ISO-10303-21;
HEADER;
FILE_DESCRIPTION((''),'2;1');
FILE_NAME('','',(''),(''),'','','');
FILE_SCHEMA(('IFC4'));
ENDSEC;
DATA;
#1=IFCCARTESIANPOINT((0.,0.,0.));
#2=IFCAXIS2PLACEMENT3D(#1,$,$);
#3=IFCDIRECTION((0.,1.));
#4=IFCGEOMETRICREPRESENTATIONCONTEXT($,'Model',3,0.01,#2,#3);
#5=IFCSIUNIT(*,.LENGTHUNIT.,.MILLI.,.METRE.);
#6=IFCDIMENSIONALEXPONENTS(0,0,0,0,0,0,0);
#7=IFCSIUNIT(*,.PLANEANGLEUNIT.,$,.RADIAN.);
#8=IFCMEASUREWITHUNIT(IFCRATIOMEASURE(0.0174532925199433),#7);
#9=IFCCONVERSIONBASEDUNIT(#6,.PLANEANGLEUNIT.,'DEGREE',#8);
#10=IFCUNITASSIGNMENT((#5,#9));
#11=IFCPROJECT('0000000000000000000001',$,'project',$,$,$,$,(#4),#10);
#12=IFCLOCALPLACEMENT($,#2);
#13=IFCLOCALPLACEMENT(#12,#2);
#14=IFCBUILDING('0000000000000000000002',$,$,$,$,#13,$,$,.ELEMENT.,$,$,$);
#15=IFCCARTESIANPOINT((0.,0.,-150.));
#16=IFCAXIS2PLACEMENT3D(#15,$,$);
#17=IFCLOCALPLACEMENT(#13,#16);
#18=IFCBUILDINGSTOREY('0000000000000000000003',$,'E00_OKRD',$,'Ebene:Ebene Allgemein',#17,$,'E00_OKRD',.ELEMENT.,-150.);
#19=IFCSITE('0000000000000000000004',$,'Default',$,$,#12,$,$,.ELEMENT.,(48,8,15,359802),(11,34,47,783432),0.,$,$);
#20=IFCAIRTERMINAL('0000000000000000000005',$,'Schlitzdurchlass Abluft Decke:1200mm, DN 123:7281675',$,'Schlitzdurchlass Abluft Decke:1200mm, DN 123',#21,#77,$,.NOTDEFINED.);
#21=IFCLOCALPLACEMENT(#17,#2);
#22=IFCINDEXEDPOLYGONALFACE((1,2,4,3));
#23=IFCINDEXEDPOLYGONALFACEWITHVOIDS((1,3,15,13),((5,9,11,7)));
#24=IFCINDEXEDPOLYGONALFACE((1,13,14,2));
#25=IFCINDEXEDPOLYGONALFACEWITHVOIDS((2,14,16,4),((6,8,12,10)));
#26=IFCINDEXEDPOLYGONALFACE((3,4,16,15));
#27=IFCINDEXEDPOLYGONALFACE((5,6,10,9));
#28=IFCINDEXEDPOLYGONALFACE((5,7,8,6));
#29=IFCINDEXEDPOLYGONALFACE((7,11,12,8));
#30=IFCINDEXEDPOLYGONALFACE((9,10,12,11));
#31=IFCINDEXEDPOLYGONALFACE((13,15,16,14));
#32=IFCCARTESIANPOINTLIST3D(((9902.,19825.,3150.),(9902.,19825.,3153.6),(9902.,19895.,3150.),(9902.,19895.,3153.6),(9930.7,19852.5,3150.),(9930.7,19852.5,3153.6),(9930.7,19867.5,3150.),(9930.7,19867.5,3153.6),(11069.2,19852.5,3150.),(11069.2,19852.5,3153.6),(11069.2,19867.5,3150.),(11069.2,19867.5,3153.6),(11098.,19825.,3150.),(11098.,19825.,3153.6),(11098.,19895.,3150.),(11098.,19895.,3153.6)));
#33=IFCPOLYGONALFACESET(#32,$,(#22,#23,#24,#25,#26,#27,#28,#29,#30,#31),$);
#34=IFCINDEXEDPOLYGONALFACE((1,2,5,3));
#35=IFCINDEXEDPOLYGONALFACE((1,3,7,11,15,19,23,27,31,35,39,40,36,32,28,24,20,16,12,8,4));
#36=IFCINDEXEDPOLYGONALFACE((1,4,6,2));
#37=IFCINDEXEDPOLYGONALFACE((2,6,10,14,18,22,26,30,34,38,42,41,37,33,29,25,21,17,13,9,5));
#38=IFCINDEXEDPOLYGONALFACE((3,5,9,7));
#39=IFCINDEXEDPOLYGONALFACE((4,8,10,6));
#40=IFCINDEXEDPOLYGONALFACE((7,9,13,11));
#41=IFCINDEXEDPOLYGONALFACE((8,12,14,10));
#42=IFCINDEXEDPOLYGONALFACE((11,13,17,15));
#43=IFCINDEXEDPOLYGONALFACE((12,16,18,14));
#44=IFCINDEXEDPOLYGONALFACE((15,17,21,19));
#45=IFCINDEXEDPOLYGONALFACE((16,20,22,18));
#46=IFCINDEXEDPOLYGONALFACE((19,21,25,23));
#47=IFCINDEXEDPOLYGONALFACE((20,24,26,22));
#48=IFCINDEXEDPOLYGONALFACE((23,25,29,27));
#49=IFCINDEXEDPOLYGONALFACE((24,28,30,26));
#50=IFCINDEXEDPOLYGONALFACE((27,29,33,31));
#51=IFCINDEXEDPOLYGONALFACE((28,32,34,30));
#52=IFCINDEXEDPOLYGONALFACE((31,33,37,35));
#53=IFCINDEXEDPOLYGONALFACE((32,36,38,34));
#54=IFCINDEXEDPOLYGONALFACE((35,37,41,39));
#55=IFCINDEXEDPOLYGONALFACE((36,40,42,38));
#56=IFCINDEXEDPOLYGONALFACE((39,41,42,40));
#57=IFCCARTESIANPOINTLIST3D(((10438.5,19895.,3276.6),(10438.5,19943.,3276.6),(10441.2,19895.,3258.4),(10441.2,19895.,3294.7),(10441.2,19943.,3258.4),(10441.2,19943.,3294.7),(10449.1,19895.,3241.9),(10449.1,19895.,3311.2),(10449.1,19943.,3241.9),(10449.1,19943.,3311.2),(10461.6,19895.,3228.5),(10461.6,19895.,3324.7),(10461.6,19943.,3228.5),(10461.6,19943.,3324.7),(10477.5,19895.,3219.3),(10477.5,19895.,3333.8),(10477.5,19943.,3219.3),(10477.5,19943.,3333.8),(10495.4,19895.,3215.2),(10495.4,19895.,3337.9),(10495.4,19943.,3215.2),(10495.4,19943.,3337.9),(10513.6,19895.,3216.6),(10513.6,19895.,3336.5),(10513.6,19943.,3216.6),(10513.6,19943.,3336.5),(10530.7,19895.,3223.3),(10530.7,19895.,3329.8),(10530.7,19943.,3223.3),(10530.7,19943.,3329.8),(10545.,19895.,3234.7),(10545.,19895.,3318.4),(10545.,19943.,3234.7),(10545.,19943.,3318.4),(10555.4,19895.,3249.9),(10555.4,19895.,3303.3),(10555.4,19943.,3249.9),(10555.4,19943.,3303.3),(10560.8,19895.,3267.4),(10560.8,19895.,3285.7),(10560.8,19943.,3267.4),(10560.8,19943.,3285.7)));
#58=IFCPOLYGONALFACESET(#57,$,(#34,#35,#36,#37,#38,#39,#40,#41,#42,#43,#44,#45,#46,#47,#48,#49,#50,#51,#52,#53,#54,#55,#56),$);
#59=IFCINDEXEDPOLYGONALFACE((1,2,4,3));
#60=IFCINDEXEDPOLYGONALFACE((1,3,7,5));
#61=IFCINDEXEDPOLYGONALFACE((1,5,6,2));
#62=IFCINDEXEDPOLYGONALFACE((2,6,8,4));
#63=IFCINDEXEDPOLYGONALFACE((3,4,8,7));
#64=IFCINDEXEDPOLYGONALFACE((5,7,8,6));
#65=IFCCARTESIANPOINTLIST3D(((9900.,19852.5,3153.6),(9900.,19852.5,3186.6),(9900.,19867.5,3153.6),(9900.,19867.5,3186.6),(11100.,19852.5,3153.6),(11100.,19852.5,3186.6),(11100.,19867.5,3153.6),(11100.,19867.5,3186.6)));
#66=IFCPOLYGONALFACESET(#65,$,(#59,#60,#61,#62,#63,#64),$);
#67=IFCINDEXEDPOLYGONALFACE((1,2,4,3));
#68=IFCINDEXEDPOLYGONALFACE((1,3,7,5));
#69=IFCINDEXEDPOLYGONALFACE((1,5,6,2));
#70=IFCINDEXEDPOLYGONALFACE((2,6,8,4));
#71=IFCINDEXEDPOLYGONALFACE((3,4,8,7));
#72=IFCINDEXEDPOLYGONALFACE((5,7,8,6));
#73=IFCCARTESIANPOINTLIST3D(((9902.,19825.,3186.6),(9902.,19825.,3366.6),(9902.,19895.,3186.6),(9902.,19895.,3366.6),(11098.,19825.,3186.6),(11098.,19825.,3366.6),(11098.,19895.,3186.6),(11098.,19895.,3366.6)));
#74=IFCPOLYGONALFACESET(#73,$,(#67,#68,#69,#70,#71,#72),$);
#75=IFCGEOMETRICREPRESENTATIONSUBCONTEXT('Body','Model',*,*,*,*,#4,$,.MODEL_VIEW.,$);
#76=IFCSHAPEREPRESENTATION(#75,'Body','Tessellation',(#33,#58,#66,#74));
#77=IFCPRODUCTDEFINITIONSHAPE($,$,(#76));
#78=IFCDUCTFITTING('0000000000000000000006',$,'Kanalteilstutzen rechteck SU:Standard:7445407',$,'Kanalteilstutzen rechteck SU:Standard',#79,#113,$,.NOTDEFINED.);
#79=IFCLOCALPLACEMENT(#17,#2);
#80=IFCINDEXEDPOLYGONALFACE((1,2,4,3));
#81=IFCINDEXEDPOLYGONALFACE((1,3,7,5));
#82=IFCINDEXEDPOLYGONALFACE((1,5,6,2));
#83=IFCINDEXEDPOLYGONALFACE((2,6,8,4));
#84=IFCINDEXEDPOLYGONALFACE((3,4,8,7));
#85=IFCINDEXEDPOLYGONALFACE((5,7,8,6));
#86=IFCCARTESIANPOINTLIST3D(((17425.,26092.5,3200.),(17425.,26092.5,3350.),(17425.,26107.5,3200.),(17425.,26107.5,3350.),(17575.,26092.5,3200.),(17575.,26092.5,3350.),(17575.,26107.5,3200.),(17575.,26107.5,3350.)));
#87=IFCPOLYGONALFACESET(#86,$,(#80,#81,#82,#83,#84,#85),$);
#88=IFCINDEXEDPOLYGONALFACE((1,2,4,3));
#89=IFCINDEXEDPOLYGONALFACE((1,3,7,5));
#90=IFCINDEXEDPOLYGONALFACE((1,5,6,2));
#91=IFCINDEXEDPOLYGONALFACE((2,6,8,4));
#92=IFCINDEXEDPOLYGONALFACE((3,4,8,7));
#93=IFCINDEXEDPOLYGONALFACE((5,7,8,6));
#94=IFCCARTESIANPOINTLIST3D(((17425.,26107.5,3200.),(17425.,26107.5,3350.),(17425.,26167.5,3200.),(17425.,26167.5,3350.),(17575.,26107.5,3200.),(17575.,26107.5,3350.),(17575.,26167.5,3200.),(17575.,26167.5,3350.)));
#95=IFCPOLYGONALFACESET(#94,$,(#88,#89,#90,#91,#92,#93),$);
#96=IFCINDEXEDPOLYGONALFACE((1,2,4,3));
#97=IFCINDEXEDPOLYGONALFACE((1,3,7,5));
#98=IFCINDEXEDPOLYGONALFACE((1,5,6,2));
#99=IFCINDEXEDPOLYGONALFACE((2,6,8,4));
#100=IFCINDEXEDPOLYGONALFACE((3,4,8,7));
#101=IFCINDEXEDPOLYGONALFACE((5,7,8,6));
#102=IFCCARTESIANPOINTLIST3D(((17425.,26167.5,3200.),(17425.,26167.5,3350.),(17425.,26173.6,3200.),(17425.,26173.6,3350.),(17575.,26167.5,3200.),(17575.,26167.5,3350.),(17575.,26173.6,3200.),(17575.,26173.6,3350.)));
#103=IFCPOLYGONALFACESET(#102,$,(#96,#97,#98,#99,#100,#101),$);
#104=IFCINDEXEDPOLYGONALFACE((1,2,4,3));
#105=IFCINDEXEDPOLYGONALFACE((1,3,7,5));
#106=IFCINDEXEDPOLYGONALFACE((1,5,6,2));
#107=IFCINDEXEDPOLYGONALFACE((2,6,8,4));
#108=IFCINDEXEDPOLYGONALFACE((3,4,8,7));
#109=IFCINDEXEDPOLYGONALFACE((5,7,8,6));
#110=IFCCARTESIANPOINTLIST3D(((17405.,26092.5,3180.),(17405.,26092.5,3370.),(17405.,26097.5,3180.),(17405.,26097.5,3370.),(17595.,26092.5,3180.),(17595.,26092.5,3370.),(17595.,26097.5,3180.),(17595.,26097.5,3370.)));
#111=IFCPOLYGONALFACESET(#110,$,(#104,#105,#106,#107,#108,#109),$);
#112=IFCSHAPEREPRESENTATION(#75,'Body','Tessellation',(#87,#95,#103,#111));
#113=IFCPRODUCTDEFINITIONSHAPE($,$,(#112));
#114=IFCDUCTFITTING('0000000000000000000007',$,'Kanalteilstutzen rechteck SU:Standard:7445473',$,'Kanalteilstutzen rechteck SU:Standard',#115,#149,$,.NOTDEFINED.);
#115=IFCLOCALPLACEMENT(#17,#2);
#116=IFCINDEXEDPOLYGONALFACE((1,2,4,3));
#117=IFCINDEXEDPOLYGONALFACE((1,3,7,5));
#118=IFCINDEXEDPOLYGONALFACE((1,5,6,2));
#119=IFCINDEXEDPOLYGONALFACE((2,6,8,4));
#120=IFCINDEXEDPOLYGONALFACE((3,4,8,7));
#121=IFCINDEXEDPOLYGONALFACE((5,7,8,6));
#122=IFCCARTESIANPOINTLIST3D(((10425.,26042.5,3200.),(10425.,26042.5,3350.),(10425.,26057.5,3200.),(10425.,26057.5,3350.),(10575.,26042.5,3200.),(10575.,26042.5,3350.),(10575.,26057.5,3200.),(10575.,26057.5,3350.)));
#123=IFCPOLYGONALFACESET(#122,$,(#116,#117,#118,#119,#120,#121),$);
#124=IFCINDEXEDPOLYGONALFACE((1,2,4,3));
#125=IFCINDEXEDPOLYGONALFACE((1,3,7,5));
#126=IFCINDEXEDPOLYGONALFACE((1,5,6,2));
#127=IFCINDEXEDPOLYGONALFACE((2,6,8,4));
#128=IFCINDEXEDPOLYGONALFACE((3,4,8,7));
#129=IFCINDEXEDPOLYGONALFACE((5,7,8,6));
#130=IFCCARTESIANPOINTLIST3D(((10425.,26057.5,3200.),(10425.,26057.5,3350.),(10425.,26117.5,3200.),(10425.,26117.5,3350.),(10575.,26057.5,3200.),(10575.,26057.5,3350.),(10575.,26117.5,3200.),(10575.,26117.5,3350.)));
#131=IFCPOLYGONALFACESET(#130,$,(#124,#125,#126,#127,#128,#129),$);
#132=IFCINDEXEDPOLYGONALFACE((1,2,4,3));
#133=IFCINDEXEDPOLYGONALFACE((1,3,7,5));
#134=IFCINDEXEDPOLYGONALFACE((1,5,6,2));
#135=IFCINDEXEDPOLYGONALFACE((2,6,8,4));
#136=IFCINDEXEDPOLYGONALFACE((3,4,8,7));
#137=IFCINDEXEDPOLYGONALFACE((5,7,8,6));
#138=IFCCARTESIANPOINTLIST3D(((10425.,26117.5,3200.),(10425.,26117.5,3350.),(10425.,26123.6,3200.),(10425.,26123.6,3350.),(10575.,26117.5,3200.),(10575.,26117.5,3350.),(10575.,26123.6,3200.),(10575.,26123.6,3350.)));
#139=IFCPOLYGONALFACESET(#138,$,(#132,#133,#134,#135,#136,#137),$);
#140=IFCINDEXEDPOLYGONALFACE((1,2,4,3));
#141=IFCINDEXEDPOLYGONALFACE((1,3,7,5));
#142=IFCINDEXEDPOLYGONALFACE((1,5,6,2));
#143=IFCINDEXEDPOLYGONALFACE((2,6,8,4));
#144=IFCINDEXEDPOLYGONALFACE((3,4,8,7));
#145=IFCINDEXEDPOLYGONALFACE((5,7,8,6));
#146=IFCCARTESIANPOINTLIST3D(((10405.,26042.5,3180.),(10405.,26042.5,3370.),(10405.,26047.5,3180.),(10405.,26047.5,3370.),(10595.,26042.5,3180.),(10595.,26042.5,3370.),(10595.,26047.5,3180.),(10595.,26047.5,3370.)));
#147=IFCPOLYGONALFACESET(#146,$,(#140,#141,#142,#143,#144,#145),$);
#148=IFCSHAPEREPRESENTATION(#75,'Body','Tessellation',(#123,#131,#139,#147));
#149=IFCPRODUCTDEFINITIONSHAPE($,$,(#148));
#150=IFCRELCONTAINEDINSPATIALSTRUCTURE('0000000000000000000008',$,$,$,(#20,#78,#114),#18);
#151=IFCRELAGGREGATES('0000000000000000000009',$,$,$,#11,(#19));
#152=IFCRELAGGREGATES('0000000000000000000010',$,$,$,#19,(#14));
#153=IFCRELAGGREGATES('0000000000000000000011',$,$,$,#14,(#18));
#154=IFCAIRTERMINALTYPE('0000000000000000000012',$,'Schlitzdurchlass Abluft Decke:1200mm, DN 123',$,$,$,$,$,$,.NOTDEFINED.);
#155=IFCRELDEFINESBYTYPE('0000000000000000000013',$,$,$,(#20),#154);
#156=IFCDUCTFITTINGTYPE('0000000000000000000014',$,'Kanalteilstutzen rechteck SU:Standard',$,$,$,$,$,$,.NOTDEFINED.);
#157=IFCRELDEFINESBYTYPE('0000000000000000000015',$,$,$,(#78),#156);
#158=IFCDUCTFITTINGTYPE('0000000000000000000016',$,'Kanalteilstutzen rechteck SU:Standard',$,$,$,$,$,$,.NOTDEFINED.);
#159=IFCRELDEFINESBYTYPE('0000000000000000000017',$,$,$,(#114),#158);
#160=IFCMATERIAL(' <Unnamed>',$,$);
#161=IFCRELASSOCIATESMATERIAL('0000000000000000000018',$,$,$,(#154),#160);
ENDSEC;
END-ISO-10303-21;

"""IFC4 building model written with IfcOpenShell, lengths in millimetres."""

from ifc_helpers import new_model, entity, si_unit, converted_unit, direction, frame, frame_2d, origin, origin_2d_with_axis, place, context, subcontext, project, spatial, polyline, rectangle, circle, outline, extrude, source, transform, mapped, material, type_object, type_shapes, element, save


model = new_model("IFC4")

# Units and contexts
model_context = context("Model", 3, precision=0.01, world=origin(), true_north=direction((0.0, 1.0)))
body_context = subcontext(model_context, "Body", "Model", "MODEL_VIEW")
ifc_project = project(units=[si_unit("LENGTHUNIT", "METRE", prefix="MILLI"), converted_unit("PLANEANGLEUNIT", "DEGREE", entity("IfcRatioMeasure", 0.0174532925199433), si_unit("PLANEANGLEUNIT", "RADIAN"), dimensions=[0, 0, 0, 0, 0, 0, 0])], contexts=[model_context])

# Site, building, storey
site_placement = place(None, origin())
site = spatial("IfcSite", under=ifc_project, at=site_placement, Name="Default", CompositionType="ELEMENT", RefLatitude=(48, 8, 15, 359802), RefLongitude=(11, 34, 47, 783432), RefElevation=0.0)
building_placement = place(site_placement, origin())
building = spatial("IfcBuilding", under=site, at=building_placement, CompositionType="ELEMENT")
storey_placement = place(building_placement, frame((0.0, 0.0, -150.0)))
storey = spatial("IfcBuildingStorey", under=building, at=storey_placement, Name="E00_OKRD", ObjectType="Ebene:Ebene Allgemein", LongName="E00_OKRD", CompositionType="ELEMENT", Elevation=-150.0)

# Air terminal
ifc_material_1 = material(Name=" <Unnamed>")
air_terminal_type_1 = type_object("IfcAirTerminalType", Name="Schlitzdurchlass Abluft Decke:1200mm, DN 123", PredefinedType="NOTDEFINED", material=ifc_material_1)
shared_shape_1 = source(origin(), body_context, "Body", "SweptSolid", [
    extrude(outline(polyline([(-598.0, -35.0), (598.0, -35.0), (598.0, 35.0), (-598.0, 35.0), (-598.0, -35.0)]), holes=[polyline([(-569.2, -7.5), (-569.2, 7.5), (569.2, 7.5), (569.2, -7.5), (-569.2, -7.5)])]), frame((0.0, 0.0, 0.0), z_axis=(0.0, 0.0, 1.0), x_axis=(-1.0, 0.0, 0.0)), (0.0, 0.0, 1.0), 3.6),
    extrude(circle(Radius=61.5, at=frame_2d((0.0, 0.0), x_axis=(1.0, 0.0))), frame((0.0, 35.0, 126.6), z_axis=(0.0, 1.0, 0.0), x_axis=(-1.0, 0.0, 0.0)), (0.0, 0.0, 1.0), 48.0),
    extrude(rectangle(XDim=1200.0, YDim=15.0, at=origin_2d_with_axis()), frame((0.0, 0.0, 3.6), z_axis=(0.0, 0.0, 1.0), x_axis=(-1.0, 0.0, 0.0)), (0.0, 0.0, 1.0), 33.0),
    extrude(rectangle(XDim=1196.0, YDim=70.0, at=origin_2d_with_axis()), frame((0.0, 0.0, 36.6), z_axis=(0.0, 0.0, 1.0), x_axis=(-1.0, 0.0, 0.0)), (0.0, 0.0, 1.0), 180.0),
])
type_shapes(air_terminal_type_1, [shared_shape_1])
for number, where, name in (
    (1, (10500.0, 19860.0, 3150.0), "Schlitzdurchlass Abluft Decke:1200mm, DN 123:7281675"),
):
    element("IfcAirTerminal", number, at=place(storey_placement, frame(where)), inside=storey, type_object=air_terminal_type_1, Name=name, ObjectType="Schlitzdurchlass Abluft Decke:1200mm, DN 123", PredefinedType="NOTDEFINED", context=body_context, shape_type="MappedRepresentation", body=[
        mapped(shared_shape_1, transform((0.0, 0.0, 0.0), scale=1.0)),
    ])

# Duct fittings
duct_fitting_type_1 = type_object("IfcDuctFittingType", Name="Kanalteilstutzen rechteck SU:Standard", PredefinedType="NOTDEFINED")
shared_shape_2 = source(origin(), body_context, "Body", "SweptSolid", [
    extrude(rectangle(XDim=150.0, YDim=15.0, at=origin_2d_with_axis()), frame((67.5, 0.0, -75.0), z_axis=(0.0, 0.0, 1.0), x_axis=(0.0, -1.0, 0.0)), (0.0, 0.0, 1.0), 150.0),
    extrude(rectangle(XDim=150.0, YDim=60.0, at=frame_2d((0.0, 0.0), x_axis=(1.0, 0.0))), frame((30.0, 0.0, -75.0), z_axis=(0.0, 0.0, 1.0), x_axis=(0.0, -1.0, 0.0)), (0.0, 0.0, 1.0), 150.0),
    extrude(rectangle(XDim=150.0, YDim=6.1, at=frame_2d((0.0, 0.0), x_axis=(1.0, 0.0))), frame((-3.0, 0.0, -75.0), z_axis=(0.0, 0.0, 1.0), x_axis=(0.0, -1.0, 0.0)), (0.0, 0.0, 1.0), 150.0),
    extrude(rectangle(XDim=190.0, YDim=5.0, at=origin_2d_with_axis()), frame((72.5, 0.0, -95.0), z_axis=(0.0, 0.0, 1.0), x_axis=(0.0, -1.0, 0.0)), (0.0, 0.0, 1.0), 190.0),
])
type_shapes(duct_fitting_type_1, [shared_shape_2])
duct_fitting_1_placement = place(storey_placement, frame((17500.0, 26167.5, 3275.0), z_axis=(0.0, 0.0, -1.0), x_axis=(0.0, -1.0, 0.0)))
element("IfcDuctFitting", 2, at=duct_fitting_1_placement, inside=storey, type_object=duct_fitting_type_1, Name="Kanalteilstutzen rechteck SU:Standard:7445407", ObjectType="Kanalteilstutzen rechteck SU:Standard", PredefinedType="NOTDEFINED", context=body_context, shape_type="MappedRepresentation", body=[
    mapped(shared_shape_2, transform((0.0, 0.0, 0.0), scale=1.0)),
])
duct_fitting_type_2 = type_object("IfcDuctFittingType", Name="Kanalteilstutzen rechteck SU:Standard", PredefinedType="NOTDEFINED")
shared_shape_3 = source(origin(), body_context, "Body", "SweptSolid", [
    extrude(rectangle(XDim=15.0, YDim=150.0, at=frame_2d((0.0, 0.0), x_axis=(1.0, 0.0))), frame((67.5, 0.0, -75.0)), (0.0, 0.0, 1.0), 150.0),
    extrude(rectangle(XDim=60.0, YDim=150.0, at=frame_2d((0.0, 0.0), x_axis=(1.0, 0.0))), frame((30.0, 0.0, -75.0)), (0.0, 0.0, 1.0), 150.0),
    extrude(rectangle(XDim=6.1, YDim=150.0, at=frame_2d((0.0, 0.0), x_axis=(1.0, 0.0))), frame((-3.0, 0.0, -75.0)), (0.0, 0.0, 1.0), 150.0),
    extrude(rectangle(XDim=5.0, YDim=190.0, at=origin_2d_with_axis()), frame((72.5, 0.0, -95.0)), (0.0, 0.0, 1.0), 190.0),
])
type_shapes(duct_fitting_type_2, [shared_shape_3])
duct_fitting_2_placement = place(storey_placement, frame((10500.0, 26117.5, 3275.0), z_axis=(0.0, 0.0, -1.0), x_axis=(0.0, -1.0, 0.0)))
element("IfcDuctFitting", 3, at=duct_fitting_2_placement, inside=storey, type_object=duct_fitting_type_2, Name="Kanalteilstutzen rechteck SU:Standard:7445473", ObjectType="Kanalteilstutzen rechteck SU:Standard", PredefinedType="NOTDEFINED", context=body_context, shape_type="MappedRepresentation", body=[
    mapped(shared_shape_3, transform((0.0, 0.0, 0.0), scale=1.0)),
])

save(model, "model.ifc")
